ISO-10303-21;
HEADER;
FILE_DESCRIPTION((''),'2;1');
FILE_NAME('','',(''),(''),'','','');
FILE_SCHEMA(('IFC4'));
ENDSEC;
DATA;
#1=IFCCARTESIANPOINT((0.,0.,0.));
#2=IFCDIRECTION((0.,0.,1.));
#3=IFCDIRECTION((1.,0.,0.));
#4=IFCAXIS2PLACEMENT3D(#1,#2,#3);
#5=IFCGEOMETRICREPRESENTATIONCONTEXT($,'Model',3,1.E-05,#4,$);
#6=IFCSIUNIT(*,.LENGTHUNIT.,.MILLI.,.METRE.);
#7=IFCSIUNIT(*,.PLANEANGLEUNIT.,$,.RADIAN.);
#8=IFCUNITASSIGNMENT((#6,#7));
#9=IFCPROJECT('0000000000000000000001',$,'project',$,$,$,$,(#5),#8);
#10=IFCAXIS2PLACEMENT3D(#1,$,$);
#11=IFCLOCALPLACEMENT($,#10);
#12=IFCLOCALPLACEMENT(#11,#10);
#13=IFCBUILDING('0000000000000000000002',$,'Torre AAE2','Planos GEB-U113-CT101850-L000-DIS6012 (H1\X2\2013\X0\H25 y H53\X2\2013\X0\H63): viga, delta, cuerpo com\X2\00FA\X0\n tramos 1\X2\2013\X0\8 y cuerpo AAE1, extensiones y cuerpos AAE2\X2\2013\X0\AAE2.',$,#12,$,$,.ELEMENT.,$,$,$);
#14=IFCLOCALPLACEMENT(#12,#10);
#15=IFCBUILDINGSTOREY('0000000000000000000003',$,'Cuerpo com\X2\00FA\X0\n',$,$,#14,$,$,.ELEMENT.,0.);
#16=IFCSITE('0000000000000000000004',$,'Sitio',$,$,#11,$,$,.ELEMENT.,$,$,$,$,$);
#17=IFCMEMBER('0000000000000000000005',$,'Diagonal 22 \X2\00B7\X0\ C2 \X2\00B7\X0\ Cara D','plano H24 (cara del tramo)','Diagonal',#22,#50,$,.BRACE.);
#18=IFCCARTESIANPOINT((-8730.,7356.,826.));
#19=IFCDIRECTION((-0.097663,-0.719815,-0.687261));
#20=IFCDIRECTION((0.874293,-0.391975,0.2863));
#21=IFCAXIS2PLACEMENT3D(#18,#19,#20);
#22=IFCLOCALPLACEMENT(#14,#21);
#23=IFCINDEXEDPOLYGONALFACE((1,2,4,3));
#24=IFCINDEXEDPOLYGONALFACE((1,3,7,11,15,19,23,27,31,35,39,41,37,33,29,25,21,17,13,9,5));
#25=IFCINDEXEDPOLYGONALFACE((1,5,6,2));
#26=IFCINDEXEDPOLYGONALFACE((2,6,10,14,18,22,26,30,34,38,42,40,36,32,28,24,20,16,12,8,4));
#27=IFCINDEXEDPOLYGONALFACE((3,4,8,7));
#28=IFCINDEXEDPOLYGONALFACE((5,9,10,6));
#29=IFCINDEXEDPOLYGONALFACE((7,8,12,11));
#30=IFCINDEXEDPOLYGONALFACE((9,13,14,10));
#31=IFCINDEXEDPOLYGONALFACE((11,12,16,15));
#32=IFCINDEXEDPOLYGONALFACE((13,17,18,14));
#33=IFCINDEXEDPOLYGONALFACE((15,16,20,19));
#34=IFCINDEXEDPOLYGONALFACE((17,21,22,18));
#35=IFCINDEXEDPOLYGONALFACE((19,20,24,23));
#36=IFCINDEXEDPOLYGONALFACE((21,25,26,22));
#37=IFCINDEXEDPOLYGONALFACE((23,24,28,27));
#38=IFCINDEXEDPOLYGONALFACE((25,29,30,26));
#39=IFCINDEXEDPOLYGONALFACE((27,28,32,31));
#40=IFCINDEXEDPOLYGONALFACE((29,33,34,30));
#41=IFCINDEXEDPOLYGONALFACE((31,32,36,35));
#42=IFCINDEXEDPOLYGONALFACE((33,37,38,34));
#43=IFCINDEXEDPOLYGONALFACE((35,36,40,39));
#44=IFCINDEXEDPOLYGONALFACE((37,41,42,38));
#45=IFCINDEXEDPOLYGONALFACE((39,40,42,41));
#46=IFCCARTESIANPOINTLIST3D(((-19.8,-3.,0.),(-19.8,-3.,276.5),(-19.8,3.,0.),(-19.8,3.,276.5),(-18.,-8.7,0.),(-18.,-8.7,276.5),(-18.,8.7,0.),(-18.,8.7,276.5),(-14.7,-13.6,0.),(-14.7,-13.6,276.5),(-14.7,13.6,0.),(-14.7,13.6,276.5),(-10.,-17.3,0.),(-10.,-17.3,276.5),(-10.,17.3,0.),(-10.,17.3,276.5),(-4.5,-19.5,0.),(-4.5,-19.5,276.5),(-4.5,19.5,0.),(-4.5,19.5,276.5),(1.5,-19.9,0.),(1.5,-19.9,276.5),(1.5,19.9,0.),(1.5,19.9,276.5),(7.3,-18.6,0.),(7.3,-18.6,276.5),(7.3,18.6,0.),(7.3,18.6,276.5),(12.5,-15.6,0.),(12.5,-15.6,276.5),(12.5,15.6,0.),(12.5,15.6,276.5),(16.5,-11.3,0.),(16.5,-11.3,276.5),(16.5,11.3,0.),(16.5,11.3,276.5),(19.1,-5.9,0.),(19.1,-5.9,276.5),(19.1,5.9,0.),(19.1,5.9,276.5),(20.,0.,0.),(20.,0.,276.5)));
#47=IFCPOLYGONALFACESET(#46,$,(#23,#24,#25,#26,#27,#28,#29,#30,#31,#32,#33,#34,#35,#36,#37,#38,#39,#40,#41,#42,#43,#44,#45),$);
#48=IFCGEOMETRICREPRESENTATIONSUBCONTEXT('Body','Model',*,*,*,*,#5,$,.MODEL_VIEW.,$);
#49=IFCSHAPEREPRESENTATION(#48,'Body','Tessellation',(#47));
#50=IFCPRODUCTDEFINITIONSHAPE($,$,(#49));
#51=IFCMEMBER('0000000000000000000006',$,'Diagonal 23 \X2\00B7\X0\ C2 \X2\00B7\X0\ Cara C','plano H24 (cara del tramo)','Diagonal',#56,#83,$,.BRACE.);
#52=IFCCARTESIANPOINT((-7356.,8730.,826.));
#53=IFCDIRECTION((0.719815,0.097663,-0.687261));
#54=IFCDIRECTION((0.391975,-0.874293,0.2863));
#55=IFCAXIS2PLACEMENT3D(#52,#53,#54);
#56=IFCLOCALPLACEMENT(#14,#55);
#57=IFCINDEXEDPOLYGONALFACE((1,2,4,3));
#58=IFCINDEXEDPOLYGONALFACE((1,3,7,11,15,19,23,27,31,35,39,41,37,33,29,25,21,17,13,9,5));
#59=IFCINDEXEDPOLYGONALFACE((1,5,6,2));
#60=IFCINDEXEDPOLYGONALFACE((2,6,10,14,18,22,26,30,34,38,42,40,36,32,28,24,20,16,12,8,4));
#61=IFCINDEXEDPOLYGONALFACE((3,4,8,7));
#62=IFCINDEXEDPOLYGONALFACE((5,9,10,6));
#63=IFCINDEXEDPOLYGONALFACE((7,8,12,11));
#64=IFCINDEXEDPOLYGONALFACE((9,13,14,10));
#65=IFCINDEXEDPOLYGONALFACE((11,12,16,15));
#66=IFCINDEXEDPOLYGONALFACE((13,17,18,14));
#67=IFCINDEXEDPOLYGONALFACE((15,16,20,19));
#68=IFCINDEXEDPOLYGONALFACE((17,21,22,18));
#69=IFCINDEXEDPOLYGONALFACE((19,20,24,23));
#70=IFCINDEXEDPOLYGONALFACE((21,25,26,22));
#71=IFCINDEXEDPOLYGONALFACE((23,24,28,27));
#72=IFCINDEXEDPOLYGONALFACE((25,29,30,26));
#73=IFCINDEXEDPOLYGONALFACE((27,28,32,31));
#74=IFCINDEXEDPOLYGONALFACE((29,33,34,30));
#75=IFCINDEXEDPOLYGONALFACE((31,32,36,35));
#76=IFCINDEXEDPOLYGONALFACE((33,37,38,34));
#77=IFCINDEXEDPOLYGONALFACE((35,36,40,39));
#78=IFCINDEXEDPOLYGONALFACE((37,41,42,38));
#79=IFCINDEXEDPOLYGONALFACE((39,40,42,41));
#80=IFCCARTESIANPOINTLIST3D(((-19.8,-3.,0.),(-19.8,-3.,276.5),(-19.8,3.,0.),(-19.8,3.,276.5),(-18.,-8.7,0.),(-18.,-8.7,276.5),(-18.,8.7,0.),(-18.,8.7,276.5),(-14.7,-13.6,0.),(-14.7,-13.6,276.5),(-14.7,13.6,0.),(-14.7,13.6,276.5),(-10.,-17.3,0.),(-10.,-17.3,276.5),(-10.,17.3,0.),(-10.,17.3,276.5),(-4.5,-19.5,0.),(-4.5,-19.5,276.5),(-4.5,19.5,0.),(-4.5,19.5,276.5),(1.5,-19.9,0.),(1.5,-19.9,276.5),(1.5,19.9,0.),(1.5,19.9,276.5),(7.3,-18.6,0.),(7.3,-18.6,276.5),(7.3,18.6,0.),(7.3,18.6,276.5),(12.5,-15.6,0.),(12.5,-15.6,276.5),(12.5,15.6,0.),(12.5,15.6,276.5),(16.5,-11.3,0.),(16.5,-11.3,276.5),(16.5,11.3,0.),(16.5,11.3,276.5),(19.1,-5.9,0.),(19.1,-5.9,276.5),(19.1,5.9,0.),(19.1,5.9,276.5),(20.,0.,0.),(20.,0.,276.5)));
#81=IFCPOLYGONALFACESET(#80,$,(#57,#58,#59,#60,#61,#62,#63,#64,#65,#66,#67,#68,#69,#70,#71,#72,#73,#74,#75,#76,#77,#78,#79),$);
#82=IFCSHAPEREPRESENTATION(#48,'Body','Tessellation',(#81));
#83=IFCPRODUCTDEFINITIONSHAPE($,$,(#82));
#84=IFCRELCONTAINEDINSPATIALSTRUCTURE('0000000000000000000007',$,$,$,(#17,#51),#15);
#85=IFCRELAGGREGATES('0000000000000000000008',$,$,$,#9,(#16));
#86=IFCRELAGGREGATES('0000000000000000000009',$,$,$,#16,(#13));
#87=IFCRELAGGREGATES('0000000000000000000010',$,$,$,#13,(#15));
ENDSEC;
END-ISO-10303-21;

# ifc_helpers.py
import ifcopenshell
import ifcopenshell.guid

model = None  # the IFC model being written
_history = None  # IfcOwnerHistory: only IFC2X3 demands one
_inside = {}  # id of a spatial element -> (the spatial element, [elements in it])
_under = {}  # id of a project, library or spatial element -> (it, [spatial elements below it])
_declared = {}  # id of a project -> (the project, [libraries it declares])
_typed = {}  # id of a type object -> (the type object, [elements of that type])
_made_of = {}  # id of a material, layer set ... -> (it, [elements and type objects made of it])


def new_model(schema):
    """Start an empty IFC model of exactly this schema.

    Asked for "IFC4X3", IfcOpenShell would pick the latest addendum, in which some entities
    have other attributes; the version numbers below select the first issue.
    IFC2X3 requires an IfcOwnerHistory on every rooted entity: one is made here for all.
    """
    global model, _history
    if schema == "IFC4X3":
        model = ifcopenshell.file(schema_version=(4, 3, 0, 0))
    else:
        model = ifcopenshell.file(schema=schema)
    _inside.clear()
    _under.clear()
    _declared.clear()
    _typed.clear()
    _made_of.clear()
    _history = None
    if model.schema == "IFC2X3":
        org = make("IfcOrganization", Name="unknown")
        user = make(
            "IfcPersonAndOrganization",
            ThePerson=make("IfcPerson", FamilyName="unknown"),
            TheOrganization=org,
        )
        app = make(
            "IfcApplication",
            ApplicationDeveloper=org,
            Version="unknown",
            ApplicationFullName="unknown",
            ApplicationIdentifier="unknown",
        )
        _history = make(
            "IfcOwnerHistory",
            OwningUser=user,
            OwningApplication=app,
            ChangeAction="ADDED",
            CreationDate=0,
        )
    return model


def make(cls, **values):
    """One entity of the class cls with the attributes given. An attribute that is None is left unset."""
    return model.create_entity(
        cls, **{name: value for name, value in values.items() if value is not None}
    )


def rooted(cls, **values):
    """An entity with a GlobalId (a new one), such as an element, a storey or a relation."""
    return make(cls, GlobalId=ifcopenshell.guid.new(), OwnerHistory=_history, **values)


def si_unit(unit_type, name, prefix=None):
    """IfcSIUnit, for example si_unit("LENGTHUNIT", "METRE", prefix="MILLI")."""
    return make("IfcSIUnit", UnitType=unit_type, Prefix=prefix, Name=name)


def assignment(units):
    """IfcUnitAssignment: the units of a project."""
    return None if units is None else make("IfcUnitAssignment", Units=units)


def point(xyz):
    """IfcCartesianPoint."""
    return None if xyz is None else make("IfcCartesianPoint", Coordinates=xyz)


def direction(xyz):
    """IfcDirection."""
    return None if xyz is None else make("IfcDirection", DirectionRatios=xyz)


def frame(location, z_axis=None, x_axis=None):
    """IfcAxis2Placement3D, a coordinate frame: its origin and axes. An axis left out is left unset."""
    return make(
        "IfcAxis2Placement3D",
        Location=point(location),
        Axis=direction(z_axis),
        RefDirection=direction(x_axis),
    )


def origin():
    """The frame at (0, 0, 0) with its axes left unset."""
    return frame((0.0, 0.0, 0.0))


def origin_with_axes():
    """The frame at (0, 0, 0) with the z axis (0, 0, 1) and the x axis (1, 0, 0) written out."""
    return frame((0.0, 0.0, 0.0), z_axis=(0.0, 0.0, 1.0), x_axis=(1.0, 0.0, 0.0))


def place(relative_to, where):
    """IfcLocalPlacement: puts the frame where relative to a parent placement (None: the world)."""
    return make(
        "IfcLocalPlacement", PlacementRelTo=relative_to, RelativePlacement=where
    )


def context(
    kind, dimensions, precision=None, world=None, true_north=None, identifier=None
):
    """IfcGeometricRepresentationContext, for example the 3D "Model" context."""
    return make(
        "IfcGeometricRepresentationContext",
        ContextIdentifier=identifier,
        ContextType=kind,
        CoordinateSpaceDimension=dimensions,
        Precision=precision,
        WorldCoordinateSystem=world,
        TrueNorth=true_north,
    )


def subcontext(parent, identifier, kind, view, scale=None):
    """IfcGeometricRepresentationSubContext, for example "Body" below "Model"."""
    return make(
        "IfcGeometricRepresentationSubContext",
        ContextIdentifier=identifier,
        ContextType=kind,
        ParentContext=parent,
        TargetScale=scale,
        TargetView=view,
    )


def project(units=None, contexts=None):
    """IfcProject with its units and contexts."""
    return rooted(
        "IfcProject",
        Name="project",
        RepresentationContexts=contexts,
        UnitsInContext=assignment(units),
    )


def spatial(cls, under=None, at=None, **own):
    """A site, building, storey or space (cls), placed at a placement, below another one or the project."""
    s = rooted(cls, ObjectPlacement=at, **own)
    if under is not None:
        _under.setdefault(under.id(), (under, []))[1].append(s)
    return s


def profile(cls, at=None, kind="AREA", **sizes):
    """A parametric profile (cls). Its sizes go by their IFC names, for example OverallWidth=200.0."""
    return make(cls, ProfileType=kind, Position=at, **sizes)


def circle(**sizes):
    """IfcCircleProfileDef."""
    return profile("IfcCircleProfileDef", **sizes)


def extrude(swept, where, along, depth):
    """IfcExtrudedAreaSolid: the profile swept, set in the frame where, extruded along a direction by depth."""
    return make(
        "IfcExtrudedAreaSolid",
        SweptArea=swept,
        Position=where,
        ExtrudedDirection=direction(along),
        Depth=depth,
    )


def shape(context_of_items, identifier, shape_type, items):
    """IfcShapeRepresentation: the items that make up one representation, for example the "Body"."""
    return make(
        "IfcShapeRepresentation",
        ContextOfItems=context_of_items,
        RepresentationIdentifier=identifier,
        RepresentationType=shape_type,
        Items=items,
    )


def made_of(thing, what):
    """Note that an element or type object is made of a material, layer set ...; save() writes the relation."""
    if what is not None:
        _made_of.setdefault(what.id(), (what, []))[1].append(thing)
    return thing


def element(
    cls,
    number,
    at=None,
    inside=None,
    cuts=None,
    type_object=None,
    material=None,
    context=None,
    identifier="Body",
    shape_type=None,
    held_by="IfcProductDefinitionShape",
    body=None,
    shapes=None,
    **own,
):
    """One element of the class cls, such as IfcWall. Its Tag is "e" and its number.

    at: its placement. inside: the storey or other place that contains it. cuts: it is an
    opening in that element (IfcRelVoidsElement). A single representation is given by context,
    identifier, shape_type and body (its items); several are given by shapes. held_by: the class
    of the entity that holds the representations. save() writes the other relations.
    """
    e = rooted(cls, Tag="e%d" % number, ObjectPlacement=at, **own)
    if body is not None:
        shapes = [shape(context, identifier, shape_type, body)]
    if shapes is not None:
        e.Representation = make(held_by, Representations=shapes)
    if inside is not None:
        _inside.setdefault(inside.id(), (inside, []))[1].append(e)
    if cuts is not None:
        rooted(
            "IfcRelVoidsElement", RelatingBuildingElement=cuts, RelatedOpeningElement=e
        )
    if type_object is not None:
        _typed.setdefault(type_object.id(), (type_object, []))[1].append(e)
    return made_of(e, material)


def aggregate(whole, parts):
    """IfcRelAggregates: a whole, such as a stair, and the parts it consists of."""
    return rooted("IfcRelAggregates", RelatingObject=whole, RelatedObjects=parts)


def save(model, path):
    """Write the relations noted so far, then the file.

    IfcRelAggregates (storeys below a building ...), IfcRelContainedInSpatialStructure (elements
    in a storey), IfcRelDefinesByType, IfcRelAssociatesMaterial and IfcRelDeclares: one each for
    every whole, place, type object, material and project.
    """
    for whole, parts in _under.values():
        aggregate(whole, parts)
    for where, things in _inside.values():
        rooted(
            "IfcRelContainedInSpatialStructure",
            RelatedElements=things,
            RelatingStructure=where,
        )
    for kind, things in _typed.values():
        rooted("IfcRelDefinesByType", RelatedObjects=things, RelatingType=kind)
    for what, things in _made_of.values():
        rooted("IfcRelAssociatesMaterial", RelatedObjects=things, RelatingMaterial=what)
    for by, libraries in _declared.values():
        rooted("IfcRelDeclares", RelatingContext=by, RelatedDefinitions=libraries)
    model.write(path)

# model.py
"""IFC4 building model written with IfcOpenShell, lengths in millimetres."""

from ifc_helpers import new_model, si_unit, frame, origin, origin_with_axes, place, context, subcontext, project, spatial, circle, extrude, element, save


model = new_model("IFC4")

# Units and contexts
model_context = context("Model", 3, precision=1e-05, world=origin_with_axes())
body_context = subcontext(model_context, "Body", "Model", "MODEL_VIEW")
ifc_project = project(units=[si_unit("LENGTHUNIT", "METRE", prefix="MILLI"), si_unit("PLANEANGLEUNIT", "RADIAN")], contexts=[model_context])

# Site, building, storey
site_placement = place(None, origin())
site = spatial("IfcSite", under=ifc_project, at=site_placement, Name="Sitio", CompositionType="ELEMENT")
building_placement = place(site_placement, origin())
building = spatial("IfcBuilding", under=site, at=building_placement, Name="Torre AAE2", Description="Planos GEB-U113-CT101850-L000-DIS6012 (H1–H25 y H53–H63): viga, delta, cuerpo común tramos 1–8 y cuerpo AAE1, extensiones y cuerpos AAE2–AAE2.", CompositionType="ELEMENT")
storey_placement = place(building_placement, origin())
storey = spatial("IfcBuildingStorey", under=building, at=storey_placement, Name="Cuerpo común", CompositionType="ELEMENT", Elevation=0.0)

# Members
for number, where, z_axis, x_axis, name in (
    (1, (-8730.0, 7356.0, 826.0), (-0.097663, -0.719815, -0.687261), (0.874293, -0.391975, 0.2863), "Diagonal 22 · C2 · Cara D"),
    (2, (-7356.0, 8730.0, 826.0), (0.719815, 0.097663, -0.687261), (0.391975, -0.874293, 0.2863), "Diagonal 23 · C2 · Cara C"),
):
    element("IfcMember", number, at=place(storey_placement, frame(where, z_axis=z_axis, x_axis=x_axis)), inside=storey, Name=name, Description="plano H24 (cara del tramo)", ObjectType="Diagonal", PredefinedType="BRACE", context=body_context, shape_type="SweptSolid", body=[
        extrude(circle(Radius=20.0), None, (0.0, 0.0, 1.0), 276.5),
    ])

save(model, "model.ifc")
